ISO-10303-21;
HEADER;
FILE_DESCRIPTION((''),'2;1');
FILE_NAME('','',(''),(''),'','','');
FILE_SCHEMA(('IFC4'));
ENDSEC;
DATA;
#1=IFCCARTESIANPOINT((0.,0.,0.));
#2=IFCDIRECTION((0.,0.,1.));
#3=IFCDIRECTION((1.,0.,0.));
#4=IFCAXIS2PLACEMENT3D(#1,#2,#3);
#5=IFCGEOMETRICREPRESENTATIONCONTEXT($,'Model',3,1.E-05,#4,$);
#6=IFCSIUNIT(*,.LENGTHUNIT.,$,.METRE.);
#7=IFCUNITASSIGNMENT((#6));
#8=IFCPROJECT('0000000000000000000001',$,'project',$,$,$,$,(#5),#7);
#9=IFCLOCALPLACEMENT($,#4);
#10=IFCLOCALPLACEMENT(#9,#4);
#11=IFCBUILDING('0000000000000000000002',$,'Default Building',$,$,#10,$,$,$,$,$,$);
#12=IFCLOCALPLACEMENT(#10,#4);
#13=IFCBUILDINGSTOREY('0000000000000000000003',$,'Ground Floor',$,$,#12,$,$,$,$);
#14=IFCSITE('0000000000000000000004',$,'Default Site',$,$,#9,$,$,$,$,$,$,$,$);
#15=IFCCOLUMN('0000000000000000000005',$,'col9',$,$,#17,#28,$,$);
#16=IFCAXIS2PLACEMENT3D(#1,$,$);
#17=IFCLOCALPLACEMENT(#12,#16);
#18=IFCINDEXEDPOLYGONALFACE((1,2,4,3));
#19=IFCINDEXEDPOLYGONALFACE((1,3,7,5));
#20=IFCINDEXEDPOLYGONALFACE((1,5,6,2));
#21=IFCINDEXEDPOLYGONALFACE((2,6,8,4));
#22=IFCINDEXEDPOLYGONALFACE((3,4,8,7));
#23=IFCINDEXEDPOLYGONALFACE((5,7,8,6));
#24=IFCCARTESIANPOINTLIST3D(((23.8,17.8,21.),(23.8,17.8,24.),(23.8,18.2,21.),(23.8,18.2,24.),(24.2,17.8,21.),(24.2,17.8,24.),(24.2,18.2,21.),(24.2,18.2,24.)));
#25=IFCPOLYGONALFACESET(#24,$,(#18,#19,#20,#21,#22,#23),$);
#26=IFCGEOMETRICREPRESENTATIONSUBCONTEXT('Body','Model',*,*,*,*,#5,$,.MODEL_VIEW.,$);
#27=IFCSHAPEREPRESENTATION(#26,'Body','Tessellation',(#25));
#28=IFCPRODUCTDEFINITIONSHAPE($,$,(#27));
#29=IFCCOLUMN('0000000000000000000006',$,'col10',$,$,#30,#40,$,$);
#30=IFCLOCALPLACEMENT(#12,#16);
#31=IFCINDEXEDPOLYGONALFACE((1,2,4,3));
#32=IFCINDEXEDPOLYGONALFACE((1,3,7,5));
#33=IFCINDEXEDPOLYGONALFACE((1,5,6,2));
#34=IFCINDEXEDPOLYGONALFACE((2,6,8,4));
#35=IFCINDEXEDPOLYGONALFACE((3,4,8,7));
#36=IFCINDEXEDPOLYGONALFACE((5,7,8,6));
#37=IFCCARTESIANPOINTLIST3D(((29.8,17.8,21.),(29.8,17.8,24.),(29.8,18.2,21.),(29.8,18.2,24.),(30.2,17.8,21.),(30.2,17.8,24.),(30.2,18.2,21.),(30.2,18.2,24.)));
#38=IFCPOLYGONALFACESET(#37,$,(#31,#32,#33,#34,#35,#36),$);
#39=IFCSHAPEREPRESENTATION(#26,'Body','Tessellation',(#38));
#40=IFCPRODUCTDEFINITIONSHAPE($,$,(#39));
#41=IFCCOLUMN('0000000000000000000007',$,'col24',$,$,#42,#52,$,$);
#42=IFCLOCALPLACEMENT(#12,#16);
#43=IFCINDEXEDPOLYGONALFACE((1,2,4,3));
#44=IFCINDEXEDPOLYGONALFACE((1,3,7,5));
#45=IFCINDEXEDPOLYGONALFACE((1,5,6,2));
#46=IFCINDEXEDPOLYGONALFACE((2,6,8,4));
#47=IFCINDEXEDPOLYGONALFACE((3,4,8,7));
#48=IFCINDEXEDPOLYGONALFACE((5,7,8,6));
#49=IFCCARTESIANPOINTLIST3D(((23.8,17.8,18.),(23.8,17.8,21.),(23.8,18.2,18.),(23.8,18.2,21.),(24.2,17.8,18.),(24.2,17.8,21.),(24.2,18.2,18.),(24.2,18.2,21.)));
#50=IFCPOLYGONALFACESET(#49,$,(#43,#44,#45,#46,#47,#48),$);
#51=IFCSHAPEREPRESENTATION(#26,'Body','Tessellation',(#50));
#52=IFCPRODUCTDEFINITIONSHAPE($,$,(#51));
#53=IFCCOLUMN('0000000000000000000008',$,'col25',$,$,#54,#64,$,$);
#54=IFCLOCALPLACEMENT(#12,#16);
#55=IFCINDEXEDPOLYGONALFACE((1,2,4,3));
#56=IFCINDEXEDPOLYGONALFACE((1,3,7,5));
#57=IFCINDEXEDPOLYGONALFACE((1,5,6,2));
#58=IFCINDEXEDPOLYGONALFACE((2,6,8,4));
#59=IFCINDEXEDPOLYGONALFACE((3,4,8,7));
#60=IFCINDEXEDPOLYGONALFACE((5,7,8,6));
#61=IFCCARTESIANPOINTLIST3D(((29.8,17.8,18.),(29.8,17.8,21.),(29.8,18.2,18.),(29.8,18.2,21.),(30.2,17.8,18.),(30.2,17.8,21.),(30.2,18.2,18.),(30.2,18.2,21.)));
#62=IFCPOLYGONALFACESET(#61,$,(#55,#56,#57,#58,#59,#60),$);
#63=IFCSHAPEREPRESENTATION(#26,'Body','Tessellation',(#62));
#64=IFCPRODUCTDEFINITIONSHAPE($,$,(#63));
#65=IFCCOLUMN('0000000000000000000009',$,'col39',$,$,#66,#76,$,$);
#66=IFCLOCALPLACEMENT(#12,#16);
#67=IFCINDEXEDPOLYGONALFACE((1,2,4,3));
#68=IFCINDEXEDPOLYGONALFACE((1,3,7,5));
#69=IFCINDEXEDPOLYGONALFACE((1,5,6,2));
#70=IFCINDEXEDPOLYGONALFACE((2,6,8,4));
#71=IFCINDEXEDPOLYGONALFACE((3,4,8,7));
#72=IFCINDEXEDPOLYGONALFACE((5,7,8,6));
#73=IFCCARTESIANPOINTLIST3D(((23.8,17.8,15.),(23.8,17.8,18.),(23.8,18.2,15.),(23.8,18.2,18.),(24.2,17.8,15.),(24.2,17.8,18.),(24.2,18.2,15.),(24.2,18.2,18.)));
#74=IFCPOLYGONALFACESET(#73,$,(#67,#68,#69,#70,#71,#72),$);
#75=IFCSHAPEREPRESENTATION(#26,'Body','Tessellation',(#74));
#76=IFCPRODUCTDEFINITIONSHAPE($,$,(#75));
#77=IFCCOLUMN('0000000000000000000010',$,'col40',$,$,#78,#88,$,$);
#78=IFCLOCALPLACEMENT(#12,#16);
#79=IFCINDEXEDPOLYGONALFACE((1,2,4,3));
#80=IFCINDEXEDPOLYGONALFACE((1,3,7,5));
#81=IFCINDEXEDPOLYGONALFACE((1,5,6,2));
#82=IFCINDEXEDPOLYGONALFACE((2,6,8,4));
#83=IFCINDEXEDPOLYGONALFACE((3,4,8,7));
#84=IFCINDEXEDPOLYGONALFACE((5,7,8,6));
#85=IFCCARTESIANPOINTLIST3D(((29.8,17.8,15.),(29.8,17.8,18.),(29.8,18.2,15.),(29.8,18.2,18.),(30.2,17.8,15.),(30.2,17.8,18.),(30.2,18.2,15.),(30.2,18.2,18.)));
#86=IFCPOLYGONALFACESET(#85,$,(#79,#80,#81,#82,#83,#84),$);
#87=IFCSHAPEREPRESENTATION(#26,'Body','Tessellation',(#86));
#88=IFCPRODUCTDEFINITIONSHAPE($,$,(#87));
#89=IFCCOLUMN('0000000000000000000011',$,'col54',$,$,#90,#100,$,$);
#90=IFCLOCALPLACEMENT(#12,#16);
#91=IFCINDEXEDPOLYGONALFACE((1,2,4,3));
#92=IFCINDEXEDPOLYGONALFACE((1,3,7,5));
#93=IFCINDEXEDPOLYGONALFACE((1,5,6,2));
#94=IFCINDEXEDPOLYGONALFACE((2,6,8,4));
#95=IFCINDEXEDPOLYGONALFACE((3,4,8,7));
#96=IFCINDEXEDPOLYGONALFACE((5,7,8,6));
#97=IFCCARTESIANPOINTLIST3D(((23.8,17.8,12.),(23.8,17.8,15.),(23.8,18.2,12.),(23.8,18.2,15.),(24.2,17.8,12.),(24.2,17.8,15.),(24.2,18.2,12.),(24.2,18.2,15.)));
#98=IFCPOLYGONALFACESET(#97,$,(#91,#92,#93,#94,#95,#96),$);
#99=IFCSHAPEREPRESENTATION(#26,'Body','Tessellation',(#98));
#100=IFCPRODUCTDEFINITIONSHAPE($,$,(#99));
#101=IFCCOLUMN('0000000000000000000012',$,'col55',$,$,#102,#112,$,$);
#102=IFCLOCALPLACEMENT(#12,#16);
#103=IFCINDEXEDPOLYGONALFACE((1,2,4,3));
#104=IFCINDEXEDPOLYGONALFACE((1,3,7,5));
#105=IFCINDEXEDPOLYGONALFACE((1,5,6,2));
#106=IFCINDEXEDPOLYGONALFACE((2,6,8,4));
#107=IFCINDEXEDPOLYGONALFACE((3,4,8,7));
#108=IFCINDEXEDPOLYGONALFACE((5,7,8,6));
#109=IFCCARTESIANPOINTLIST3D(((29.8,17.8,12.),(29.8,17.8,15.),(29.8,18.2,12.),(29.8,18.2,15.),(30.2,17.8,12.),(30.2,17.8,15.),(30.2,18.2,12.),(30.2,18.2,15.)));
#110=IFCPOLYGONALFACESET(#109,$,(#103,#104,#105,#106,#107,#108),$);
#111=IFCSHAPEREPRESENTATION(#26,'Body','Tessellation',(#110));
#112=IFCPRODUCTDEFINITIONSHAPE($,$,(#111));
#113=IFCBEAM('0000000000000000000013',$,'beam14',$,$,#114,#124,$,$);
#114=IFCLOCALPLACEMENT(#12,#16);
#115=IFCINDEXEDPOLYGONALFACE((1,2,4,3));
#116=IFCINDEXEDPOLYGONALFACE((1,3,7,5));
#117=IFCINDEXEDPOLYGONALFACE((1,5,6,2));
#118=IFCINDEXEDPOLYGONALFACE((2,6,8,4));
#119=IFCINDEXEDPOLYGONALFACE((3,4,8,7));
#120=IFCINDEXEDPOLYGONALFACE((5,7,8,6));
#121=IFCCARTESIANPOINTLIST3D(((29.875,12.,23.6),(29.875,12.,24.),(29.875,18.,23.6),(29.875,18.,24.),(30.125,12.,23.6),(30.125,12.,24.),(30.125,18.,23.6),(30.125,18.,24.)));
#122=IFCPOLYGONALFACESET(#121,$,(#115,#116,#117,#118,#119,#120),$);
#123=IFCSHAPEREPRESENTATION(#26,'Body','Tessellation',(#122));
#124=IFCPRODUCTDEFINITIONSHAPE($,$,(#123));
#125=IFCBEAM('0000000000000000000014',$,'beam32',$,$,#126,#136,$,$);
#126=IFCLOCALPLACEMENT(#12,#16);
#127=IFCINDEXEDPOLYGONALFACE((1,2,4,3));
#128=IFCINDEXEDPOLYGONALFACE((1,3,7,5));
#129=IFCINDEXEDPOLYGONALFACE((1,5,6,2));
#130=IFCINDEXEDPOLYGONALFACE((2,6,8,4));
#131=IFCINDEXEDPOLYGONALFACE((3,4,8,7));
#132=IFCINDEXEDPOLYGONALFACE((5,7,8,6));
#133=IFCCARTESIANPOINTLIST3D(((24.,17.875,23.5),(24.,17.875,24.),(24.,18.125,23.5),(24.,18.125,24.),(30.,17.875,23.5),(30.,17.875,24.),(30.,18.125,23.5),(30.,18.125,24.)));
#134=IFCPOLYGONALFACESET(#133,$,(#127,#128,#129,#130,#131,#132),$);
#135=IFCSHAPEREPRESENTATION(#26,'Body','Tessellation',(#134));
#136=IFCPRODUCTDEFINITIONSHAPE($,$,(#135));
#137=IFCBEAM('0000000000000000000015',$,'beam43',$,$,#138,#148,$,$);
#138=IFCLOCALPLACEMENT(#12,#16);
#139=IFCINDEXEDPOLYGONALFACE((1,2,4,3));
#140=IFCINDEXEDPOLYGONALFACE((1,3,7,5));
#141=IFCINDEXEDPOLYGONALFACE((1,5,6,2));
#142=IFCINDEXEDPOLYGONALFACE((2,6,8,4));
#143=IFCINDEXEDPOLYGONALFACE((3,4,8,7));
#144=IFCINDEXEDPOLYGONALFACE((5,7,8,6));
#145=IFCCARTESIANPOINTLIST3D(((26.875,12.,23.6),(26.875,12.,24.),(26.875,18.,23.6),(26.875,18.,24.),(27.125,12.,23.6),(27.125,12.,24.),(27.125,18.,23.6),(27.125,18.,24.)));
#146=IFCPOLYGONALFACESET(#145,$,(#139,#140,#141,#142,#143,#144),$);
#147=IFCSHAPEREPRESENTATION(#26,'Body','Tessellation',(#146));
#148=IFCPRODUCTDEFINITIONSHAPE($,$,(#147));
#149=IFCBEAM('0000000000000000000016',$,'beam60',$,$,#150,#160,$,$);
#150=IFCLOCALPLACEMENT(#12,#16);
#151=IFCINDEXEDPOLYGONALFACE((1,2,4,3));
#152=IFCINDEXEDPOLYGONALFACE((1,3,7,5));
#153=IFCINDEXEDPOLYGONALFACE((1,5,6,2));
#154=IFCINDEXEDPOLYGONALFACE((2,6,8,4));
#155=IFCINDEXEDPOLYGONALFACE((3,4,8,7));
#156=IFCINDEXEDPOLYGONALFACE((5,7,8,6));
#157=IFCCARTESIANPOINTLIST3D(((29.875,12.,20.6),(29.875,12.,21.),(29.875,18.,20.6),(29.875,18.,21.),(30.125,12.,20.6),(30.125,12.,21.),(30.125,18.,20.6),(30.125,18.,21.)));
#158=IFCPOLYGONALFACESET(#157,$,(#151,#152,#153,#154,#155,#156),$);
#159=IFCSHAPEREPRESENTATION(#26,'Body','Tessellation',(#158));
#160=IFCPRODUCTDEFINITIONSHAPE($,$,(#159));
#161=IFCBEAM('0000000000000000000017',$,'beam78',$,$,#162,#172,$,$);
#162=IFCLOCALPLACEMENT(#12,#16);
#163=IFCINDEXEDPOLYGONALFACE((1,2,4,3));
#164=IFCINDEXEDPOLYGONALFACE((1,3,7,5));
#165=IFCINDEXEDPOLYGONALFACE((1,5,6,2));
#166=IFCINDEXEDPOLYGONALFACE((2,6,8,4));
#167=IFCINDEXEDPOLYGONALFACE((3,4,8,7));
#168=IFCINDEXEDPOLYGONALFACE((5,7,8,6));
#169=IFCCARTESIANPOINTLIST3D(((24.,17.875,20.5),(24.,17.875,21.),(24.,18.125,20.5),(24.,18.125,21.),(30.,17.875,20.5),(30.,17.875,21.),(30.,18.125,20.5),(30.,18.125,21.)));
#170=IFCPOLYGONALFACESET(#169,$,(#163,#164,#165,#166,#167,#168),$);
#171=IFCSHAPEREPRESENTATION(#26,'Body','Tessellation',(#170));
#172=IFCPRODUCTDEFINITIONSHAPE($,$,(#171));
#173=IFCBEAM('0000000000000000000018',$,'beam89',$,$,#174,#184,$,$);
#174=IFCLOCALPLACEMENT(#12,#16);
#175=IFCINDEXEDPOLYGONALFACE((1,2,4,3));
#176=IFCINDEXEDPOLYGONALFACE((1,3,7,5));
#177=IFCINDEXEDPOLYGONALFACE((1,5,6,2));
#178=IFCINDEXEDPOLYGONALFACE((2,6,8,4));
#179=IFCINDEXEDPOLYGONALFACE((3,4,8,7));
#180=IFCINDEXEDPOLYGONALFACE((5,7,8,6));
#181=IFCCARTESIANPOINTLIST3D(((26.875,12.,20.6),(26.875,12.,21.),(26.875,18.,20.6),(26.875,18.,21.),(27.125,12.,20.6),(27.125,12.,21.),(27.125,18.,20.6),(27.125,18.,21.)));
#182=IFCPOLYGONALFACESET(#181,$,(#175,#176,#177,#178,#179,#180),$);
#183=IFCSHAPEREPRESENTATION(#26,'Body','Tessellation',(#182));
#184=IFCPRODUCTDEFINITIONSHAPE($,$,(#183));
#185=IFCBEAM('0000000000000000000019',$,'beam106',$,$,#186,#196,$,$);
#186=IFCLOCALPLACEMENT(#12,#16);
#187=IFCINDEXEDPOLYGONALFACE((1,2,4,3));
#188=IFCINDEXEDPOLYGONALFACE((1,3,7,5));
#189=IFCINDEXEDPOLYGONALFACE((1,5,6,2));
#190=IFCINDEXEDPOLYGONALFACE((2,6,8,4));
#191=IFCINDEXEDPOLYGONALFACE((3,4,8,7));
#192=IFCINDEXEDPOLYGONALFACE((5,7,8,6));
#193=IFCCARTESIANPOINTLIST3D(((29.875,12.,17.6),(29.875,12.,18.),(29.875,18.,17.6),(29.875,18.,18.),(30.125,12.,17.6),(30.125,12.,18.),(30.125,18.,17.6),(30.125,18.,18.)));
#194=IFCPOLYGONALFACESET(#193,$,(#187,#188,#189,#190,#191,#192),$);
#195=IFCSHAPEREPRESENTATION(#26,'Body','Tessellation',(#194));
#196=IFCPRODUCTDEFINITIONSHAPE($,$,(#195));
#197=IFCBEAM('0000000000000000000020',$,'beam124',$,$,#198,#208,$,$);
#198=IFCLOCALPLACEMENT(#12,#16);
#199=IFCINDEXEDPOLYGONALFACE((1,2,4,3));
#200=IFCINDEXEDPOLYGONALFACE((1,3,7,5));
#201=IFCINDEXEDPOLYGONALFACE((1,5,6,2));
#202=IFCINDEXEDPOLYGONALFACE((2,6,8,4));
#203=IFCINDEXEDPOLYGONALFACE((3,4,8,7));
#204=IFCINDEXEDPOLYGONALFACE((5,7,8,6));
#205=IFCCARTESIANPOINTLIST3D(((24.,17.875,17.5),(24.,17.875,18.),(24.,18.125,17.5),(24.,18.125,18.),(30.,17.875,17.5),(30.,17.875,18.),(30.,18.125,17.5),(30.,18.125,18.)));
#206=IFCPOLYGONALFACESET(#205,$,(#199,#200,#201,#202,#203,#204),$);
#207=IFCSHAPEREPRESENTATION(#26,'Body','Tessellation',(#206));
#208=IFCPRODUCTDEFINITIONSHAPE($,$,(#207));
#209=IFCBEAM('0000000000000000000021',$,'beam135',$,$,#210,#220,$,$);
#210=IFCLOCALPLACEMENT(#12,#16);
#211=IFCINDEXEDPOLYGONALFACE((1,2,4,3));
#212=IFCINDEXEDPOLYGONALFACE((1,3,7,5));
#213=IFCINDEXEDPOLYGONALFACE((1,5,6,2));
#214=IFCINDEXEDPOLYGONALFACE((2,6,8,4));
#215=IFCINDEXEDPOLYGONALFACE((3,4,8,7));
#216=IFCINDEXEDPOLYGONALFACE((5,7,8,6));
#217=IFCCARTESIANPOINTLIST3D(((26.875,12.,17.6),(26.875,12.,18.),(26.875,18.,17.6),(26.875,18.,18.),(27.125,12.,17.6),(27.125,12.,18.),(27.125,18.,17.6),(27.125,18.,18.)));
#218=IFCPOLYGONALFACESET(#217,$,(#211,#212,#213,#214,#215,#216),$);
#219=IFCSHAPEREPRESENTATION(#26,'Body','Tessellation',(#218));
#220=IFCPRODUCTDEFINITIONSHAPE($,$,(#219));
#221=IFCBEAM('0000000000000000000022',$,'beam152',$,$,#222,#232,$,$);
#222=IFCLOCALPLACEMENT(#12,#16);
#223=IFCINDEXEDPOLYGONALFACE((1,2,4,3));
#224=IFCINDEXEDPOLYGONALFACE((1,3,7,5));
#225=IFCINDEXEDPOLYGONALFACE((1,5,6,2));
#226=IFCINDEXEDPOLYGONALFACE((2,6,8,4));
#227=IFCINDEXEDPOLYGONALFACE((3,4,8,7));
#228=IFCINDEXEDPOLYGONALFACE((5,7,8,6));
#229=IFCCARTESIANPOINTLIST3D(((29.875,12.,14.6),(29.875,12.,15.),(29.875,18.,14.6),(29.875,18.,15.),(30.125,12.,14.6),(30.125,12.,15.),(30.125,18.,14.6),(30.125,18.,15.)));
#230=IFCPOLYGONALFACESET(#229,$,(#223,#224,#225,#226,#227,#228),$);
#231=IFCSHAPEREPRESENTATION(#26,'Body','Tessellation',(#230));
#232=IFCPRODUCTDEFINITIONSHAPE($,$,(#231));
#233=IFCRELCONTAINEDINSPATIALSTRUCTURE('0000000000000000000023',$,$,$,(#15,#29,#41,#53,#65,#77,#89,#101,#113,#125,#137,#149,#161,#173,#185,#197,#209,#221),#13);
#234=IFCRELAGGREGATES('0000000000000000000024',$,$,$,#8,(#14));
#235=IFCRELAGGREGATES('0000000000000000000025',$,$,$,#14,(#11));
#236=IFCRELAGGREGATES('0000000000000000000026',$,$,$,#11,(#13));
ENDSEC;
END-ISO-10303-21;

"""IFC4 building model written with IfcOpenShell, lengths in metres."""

from ifc_helpers import new_model, si_unit, frame, origin_with_axes, place, context, subcontext, project, spatial, indexed_curve, outline, extrude, element, save


model = new_model("IFC4")

# Units and contexts
model_context = context("Model", 3, precision=1e-05, world=origin_with_axes())
body_context = subcontext(model_context, "Body", "Model", "MODEL_VIEW")
ifc_project = project(units=[si_unit("LENGTHUNIT", "METRE")], contexts=[model_context])

# Site, building, storey
site_placement = place(None, origin_with_axes())
site = spatial("IfcSite", under=ifc_project, at=site_placement, Name="Default Site")
building_placement = place(site_placement, origin_with_axes())
building = spatial("IfcBuilding", under=site, at=building_placement, Name="Default Building")
storey_placement = place(building_placement, origin_with_axes())
storey = spatial("IfcBuildingStorey", under=building, at=storey_placement, Name="Ground Floor")

# Columns
for number, where, z_axis, x_axis, name in (
    (1, (23.8, 17.8, 21.0), (0.0, 0.0, 1.0), (1.0, 0.0, 0.0), "col9"),
    (2, (29.8, 17.8, 21.0), (0.0, 0.0, 1.0), (1.0, 0.0, 0.0), "col10"),
    (3, (23.8, 17.8, 18.0), (0.0, 0.0, 1.0), (1.0, 0.0, 0.0), "col24"),
    (4, (29.8, 17.8, 18.0), (0.0, 0.0, 1.0), (1.0, 0.0, 0.0), "col25"),
    (5, (23.8, 17.8, 15.0), (0.0, 0.0, 1.0), (1.0, 0.0, 0.0), "col39"),
    (6, (29.8, 17.8, 15.0), (0.0, 0.0, 1.0), (1.0, 0.0, 0.0), "col40"),
    (7, (23.8, 17.8, 12.0), (0.0, 0.0, 1.0), (1.0, 0.0, 0.0), "col54"),
    (8, (29.8, 17.8, 12.0), (0.0, 0.0, 1.0), (1.0, 0.0, 0.0), "col55"),
):
    element("IfcColumn", number, at=place(storey_placement, frame(where, z_axis=z_axis, x_axis=x_axis)), inside=storey, Name=name, context=body_context, shape_type="SweptSolid", body=[
        extrude(outline(indexed_curve([(0.0, 0.0), (0.0, 0.4), (0.4, 0.4), (0.4, 0.0), (0.0, 0.0)], self_intersect=False)), origin_with_axes(), (0.0, 0.0, 1.0), 3.0),
    ])

# Beams
beam_1_placement = place(storey_placement, frame((30.125, 12.0, 23.6), z_axis=(0.0, 0.0, 1.0), x_axis=(0.0, 1.0, 0.0)))
element("IfcBeam", 9, at=beam_1_placement, inside=storey, Name="beam14", context=body_context, shape_type="SweptSolid", body=[
    extrude(outline(indexed_curve([(0.0, 0.0), (0.0, 0.25), (6.0, 0.25), (6.0, 0.0), (0.0, 0.0)], self_intersect=False)), origin_with_axes(), (0.0, 0.0, 1.0), 0.4),
])
beam_2_placement = place(storey_placement, frame((24.0, 17.875, 23.5), z_axis=(0.0, 0.0, 1.0), x_axis=(1.0, 0.0, 0.0)))
element("IfcBeam", 10, at=beam_2_placement, inside=storey, Name="beam32", context=body_context, shape_type="SweptSolid", body=[
    extrude(outline(indexed_curve([(0.0, 0.0), (0.0, 0.25), (6.0, 0.25), (6.0, 0.0), (0.0, 0.0)], self_intersect=False)), origin_with_axes(), (0.0, 0.0, 1.0), 0.5),
])
for number, where, z_axis, x_axis, name in (
    (11, (26.875, 18.0, 23.6), (0.0, 0.0, 1.0), (0.0, -1.0, 0.0), "beam43"),
    (12, (30.125, 12.0, 20.6), (0.0, 0.0, 1.0), (0.0, 1.0, 0.0), "beam60"),
):
    element("IfcBeam", number, at=place(storey_placement, frame(where, z_axis=z_axis, x_axis=x_axis)), inside=storey, Name=name, context=body_context, shape_type="SweptSolid", body=[
        extrude(outline(indexed_curve([(0.0, 0.0), (0.0, 0.25), (6.0, 0.25), (6.0, 0.0), (0.0, 0.0)], self_intersect=False)), origin_with_axes(), (0.0, 0.0, 1.0), 0.4),
    ])
beam_3_placement = place(storey_placement, frame((24.0, 17.875, 20.5), z_axis=(0.0, 0.0, 1.0), x_axis=(1.0, 0.0, 0.0)))
element("IfcBeam", 13, at=beam_3_placement, inside=storey, Name="beam78", context=body_context, shape_type="SweptSolid", body=[
    extrude(outline(indexed_curve([(0.0, 0.0), (0.0, 0.25), (6.0, 0.25), (6.0, 0.0), (0.0, 0.0)], self_intersect=False)), origin_with_axes(), (0.0, 0.0, 1.0), 0.5),
])
for number, where, z_axis, x_axis, name in (
    (14, (26.875, 18.0, 20.6), (0.0, 0.0, 1.0), (0.0, -1.0, 0.0), "beam89"),
    (15, (30.125, 12.0, 17.6), (0.0, 0.0, 1.0), (0.0, 1.0, 0.0), "beam106"),
):
    element("IfcBeam", number, at=place(storey_placement, frame(where, z_axis=z_axis, x_axis=x_axis)), inside=storey, Name=name, context=body_context, shape_type="SweptSolid", body=[
        extrude(outline(indexed_curve([(0.0, 0.0), (0.0, 0.25), (6.0, 0.25), (6.0, 0.0), (0.0, 0.0)], self_intersect=False)), origin_with_axes(), (0.0, 0.0, 1.0), 0.4),
    ])
beam_4_placement = place(storey_placement, frame((24.0, 17.875, 17.5), z_axis=(0.0, 0.0, 1.0), x_axis=(1.0, 0.0, 0.0)))
element("IfcBeam", 16, at=beam_4_placement, inside=storey, Name="beam124", context=body_context, shape_type="SweptSolid", body=[
    extrude(outline(indexed_curve([(0.0, 0.0), (0.0, 0.25), (6.0, 0.25), (6.0, 0.0), (0.0, 0.0)], self_intersect=False)), origin_with_axes(), (0.0, 0.0, 1.0), 0.5),
])
for number, where, z_axis, x_axis, name in (
    (17, (26.875, 18.0, 17.6), (0.0, 0.0, 1.0), (0.0, -1.0, 0.0), "beam135"),
    (18, (30.125, 12.0, 14.6), (0.0, 0.0, 1.0), (0.0, 1.0, 0.0), "beam152"),
):
    element("IfcBeam", number, at=place(storey_placement, frame(where, z_axis=z_axis, x_axis=x_axis)), inside=storey, Name=name, context=body_context, shape_type="SweptSolid", body=[
        extrude(outline(indexed_curve([(0.0, 0.0), (0.0, 0.25), (6.0, 0.25), (6.0, 0.0), (0.0, 0.0)], self_intersect=False)), origin_with_axes(), (0.0, 0.0, 1.0), 0.4),
    ])

save(model, "model.ifc")
